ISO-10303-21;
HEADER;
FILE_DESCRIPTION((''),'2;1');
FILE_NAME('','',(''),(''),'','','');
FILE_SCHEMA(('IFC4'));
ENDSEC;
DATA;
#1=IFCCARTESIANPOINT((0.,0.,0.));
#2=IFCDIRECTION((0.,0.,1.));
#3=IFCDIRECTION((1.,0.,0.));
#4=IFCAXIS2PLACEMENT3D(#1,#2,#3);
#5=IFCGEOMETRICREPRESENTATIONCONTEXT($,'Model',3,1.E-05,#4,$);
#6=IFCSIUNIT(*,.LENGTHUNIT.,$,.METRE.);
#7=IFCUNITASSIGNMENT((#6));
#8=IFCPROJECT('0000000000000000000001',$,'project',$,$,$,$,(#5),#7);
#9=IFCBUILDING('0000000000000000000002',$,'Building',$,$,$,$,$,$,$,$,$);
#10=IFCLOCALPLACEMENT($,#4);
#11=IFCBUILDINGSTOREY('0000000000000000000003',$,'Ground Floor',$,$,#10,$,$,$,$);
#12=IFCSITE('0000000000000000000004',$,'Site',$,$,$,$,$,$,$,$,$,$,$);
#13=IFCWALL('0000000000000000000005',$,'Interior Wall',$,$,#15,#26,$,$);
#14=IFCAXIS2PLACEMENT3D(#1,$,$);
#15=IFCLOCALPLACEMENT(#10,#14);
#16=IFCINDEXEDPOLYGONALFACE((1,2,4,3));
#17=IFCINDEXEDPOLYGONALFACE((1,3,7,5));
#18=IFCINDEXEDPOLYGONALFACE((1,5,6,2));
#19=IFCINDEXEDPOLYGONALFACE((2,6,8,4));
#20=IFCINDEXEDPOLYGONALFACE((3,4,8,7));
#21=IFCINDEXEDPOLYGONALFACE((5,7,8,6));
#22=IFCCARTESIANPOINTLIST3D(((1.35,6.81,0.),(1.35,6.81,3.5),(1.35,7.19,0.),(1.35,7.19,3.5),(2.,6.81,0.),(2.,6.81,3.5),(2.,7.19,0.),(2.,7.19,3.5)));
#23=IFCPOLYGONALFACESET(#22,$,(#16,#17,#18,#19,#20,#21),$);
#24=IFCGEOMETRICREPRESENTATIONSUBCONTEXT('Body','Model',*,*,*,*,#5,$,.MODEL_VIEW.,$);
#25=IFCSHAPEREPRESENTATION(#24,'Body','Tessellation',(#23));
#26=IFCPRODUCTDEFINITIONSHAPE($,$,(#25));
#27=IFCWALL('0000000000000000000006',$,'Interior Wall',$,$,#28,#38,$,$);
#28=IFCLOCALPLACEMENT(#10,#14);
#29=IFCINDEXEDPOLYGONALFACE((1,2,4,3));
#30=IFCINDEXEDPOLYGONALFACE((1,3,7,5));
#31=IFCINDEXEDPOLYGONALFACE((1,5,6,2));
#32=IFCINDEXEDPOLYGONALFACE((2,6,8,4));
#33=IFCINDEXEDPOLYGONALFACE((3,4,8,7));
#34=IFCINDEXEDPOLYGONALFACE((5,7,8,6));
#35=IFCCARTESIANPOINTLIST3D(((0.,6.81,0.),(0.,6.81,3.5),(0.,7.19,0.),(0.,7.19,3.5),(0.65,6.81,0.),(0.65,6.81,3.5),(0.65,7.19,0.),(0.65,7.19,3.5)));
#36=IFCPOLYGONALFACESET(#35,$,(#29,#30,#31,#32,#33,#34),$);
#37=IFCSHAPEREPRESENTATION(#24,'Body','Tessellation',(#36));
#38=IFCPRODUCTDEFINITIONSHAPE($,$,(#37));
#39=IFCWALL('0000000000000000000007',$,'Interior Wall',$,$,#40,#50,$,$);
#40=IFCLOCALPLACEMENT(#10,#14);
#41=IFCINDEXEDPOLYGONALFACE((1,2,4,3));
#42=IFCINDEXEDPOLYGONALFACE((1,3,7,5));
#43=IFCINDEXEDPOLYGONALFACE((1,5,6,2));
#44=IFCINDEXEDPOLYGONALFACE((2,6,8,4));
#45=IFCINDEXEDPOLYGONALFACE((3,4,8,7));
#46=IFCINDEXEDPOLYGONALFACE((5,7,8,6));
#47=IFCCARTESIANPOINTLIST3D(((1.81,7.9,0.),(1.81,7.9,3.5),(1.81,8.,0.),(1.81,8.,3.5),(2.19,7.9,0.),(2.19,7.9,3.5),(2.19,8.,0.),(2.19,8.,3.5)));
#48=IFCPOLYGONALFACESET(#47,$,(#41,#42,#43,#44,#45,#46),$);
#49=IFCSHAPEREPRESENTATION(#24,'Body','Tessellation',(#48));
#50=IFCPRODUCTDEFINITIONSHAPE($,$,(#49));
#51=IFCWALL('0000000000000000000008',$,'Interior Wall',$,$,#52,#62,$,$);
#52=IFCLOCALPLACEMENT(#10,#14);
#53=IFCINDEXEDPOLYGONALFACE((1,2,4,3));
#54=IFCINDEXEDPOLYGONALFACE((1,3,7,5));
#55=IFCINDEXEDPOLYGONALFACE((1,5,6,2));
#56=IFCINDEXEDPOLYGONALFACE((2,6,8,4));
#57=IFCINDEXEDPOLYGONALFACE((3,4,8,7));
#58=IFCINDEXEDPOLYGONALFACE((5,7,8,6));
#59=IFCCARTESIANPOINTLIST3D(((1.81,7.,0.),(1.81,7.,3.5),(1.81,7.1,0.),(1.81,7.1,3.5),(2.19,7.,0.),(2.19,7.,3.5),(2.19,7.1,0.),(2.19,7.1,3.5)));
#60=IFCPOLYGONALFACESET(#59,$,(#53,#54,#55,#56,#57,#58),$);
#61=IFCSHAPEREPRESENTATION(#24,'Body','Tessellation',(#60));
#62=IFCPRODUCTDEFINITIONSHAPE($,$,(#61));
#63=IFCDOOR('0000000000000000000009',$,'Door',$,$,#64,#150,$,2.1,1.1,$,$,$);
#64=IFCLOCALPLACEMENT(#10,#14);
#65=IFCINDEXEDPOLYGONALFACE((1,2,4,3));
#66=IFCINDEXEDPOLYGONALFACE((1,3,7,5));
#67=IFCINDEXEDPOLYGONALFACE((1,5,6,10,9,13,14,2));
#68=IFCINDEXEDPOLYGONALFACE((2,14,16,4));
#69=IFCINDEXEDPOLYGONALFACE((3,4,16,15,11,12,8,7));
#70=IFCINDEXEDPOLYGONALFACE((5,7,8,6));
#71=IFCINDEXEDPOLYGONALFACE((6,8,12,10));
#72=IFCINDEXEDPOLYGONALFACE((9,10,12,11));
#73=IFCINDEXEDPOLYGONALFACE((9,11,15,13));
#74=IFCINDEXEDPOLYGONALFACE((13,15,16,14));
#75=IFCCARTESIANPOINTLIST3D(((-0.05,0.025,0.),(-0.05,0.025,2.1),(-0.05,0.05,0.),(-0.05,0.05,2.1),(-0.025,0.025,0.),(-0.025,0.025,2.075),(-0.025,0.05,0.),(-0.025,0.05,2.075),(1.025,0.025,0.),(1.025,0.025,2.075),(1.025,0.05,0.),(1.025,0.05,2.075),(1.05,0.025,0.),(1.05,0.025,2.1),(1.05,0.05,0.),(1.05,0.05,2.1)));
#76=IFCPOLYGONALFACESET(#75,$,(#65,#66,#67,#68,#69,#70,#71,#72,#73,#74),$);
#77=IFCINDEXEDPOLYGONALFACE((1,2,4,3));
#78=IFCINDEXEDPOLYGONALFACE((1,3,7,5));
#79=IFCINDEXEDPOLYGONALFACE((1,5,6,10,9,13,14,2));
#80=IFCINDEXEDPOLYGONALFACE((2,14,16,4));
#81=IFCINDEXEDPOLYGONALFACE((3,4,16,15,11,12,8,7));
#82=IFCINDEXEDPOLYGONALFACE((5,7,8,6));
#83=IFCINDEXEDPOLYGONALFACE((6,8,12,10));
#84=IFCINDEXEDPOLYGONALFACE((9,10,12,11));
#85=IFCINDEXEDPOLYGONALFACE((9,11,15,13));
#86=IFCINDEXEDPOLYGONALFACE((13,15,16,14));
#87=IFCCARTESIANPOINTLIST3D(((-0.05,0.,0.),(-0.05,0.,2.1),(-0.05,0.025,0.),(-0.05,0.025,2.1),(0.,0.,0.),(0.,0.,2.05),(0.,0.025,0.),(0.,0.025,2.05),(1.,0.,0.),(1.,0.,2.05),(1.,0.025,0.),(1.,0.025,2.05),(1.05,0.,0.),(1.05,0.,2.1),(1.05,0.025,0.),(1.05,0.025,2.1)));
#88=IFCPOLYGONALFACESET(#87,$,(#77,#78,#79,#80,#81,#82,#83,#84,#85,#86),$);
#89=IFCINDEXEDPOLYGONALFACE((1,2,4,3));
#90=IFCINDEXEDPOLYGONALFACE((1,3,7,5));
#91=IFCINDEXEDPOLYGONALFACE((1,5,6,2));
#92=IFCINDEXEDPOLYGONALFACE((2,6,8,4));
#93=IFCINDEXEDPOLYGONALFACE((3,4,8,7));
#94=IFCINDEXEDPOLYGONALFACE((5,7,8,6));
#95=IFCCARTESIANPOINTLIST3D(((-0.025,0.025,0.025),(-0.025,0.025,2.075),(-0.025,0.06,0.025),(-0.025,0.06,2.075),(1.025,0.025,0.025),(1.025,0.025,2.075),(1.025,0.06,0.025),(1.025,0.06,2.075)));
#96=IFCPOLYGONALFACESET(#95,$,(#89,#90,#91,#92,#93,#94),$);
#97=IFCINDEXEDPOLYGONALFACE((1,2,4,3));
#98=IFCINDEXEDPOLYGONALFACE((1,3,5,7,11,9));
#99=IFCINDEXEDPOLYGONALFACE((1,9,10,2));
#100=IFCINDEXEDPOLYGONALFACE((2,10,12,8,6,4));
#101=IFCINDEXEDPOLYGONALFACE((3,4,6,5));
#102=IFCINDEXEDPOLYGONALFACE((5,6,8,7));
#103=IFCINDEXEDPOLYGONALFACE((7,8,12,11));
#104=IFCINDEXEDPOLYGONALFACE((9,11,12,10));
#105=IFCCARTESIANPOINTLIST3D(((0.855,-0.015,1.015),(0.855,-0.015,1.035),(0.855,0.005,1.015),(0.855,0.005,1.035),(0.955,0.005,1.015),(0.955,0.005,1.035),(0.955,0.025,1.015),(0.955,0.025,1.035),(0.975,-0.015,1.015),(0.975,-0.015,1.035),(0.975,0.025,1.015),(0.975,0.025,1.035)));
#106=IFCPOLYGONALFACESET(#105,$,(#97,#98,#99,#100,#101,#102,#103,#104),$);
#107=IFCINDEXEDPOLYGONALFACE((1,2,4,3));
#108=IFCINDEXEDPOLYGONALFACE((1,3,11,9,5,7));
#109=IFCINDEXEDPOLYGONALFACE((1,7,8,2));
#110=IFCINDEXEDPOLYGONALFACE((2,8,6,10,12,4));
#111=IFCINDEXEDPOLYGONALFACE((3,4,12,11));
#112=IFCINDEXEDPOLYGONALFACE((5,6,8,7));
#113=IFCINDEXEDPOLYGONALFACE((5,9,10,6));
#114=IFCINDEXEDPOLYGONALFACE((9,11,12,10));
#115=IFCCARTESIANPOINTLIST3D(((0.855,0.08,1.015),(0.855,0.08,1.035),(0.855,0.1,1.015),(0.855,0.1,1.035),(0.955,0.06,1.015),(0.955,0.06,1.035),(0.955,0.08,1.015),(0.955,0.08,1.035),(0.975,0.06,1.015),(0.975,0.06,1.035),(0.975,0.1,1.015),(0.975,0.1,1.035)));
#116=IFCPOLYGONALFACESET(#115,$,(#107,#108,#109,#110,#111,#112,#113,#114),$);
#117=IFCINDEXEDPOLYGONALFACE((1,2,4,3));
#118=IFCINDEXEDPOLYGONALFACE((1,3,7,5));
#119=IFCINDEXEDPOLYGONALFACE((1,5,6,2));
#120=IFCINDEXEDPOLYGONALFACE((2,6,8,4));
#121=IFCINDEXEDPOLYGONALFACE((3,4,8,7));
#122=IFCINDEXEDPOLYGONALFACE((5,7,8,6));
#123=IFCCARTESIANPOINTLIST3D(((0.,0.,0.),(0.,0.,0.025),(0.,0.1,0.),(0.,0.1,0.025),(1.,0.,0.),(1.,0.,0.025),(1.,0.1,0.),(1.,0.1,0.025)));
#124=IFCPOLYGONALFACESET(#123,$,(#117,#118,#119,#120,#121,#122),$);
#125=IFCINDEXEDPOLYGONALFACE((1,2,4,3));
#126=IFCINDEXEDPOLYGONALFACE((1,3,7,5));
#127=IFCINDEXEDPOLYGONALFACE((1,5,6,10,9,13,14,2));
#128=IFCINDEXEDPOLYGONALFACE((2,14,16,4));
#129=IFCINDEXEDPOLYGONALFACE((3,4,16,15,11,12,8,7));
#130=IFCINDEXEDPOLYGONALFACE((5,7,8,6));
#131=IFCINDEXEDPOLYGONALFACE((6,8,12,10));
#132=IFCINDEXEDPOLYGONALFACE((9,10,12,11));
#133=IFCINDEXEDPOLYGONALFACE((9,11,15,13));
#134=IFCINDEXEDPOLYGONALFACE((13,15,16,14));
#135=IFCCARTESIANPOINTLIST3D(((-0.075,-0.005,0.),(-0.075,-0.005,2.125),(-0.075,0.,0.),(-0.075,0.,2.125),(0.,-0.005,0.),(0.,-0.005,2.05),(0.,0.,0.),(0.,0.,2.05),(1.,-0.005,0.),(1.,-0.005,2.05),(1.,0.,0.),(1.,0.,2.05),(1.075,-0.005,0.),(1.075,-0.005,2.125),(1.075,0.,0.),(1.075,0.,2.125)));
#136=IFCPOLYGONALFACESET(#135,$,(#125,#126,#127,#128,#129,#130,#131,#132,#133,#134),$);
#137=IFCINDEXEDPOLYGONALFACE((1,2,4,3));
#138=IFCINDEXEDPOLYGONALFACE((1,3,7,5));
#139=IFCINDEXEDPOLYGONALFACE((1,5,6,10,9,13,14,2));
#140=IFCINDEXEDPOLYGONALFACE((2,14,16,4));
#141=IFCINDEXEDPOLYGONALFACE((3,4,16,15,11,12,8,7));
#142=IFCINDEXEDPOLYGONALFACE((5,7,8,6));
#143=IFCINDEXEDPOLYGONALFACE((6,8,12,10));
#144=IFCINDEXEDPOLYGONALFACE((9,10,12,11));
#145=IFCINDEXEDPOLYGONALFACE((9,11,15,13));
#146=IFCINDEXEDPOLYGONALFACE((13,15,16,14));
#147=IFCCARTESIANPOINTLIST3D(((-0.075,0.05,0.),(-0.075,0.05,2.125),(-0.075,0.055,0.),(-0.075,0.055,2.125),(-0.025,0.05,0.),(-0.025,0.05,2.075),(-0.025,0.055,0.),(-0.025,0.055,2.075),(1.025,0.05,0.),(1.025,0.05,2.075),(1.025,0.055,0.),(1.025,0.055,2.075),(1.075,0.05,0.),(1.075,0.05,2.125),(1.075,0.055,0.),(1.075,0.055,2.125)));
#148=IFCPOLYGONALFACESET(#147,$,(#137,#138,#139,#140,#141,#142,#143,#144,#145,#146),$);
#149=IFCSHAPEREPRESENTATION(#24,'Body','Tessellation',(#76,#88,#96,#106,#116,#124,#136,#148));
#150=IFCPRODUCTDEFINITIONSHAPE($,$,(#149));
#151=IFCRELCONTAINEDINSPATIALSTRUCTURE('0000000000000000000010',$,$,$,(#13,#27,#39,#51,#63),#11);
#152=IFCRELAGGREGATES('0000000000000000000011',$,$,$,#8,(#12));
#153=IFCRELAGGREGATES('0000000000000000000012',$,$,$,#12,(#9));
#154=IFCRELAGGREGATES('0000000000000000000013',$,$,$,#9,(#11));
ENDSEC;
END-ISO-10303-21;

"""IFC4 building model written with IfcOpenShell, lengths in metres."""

from ifc_helpers import new_model, si_unit, frame, origin_with_axes, place, context, subcontext, project, spatial, line, indexed_curve, outline, extrude, element, save


model = new_model("IFC4")

# Units and contexts
model_context = context("Model", 3, precision=1e-05, world=origin_with_axes())
body_context = subcontext(model_context, "Body", "Model", "MODEL_VIEW")
ifc_project = project(units=[si_unit("LENGTHUNIT", "METRE")], contexts=[model_context])

# Site, building, storey
site = spatial("IfcSite", under=ifc_project, Name="Site")
building = spatial("IfcBuilding", under=site, Name="Building")
storey_placement = place(None, origin_with_axes())
storey = spatial("IfcBuildingStorey", under=building, at=storey_placement, Name="Ground Floor")

# Walls
for number, where, z_axis, x_axis, name in (
    (1, (2.0, 7.0, 0.0), (0.0, 0.0, 1.0), (-1.0, 0.0, 0.0), "Interior Wall"),
    (2, (0.65, 7.0, 0.0), (0.0, 0.0, 1.0), (-1.0, 0.0, 0.0), "Interior Wall"),
):
    element("IfcWall", number, at=place(storey_placement, frame(where, z_axis=z_axis, x_axis=x_axis)), inside=storey, Name=name, context=body_context, shape_type="SweptSolid", body=[
        extrude(outline(indexed_curve([(0.0, 0.0), (0.0, 0.38), (0.65, 0.38), (0.65, 0.0), (0.0, 0.0)], self_intersect=False)), frame((0.0, -0.19, 0.0), z_axis=(0.0, 0.0, 1.0), x_axis=(1.0, 0.0, 0.0)), (0.0, 0.0, 1.0), 3.5),
    ])
for number, where, z_axis, x_axis, name in (
    (3, (2.0, 8.0, 0.0), (0.0, 0.0, 1.0), (0.0, -1.0, 0.0), "Interior Wall"),
    (4, (2.0, 7.1, 0.0), (0.0, 0.0, 1.0), (0.0, -1.0, 0.0), "Interior Wall"),
):
    element("IfcWall", number, at=place(storey_placement, frame(where, z_axis=z_axis, x_axis=x_axis)), inside=storey, Name=name, context=body_context, shape_type="SweptSolid", body=[
        extrude(outline(indexed_curve([(0.0, 0.0), (0.0, 0.38), (0.1, 0.38), (0.1, 0.0), (0.0, 0.0)], self_intersect=False)), frame((0.0, -0.19, 0.0), z_axis=(0.0, 0.0, 1.0), x_axis=(1.0, 0.0, 0.0)), (0.0, 0.0, 1.0), 3.5),
    ])

# Door
door_1_placement = place(storey_placement, frame((-0.05, 0.0, 0.0), z_axis=(0.0, 0.0, 1.0), x_axis=(1.0, 0.0, 0.0)))
element("IfcDoor", 5, at=door_1_placement, inside=storey, Name="Door", OverallHeight=2.1, OverallWidth=1.1, context=body_context, shape_type="SweptSolid", body=[
    extrude(outline(indexed_curve([(0.0, 0.0), (0.0, 2.1), (1.1, 2.1), (1.1, 0.0), (1.075, 0.0), (1.075, 2.075), (0.025, 2.075), (0.025, 0.0)], segments=[line(1, 2, 3, 4, 5, 6, 7, 8, 1)])), frame((0.0, 0.025, 0.0), z_axis=(0.0, -1.0, 0.0), x_axis=(1.0, 0.0, 0.0)), (0.0, 0.0, -1.0), 0.025),
    extrude(outline(indexed_curve([(0.0, 0.0), (0.0, 2.1), (1.1, 2.1), (1.1, 0.0), (1.05, 0.0), (1.05, 2.05), (0.05, 2.05), (0.05, 0.0)], segments=[line(1, 2, 3, 4, 5, 6, 7, 8, 1)])), frame((0.0, 0.0, 0.0), z_axis=(0.0, -1.0, 0.0), x_axis=(1.0, 0.0, 0.0)), (0.0, 0.0, -1.0), 0.025),
    extrude(outline(indexed_curve([(0.0, 0.0), (1.05, 0.0), (1.05, 0.035), (0.0, 0.035)], segments=[line(1, 2, 3, 4, 1)])), frame((0.025, 0.025, 0.025), z_axis=(0.0, 0.0, 1.0), x_axis=(1.0, 0.0, 0.0)), (0.0, 0.0, 1.0), 2.05),
    extrude(outline(indexed_curve([(0.0, 0.0), (0.0, -0.04), (-0.12, -0.04), (-0.12, -0.02), (-0.02, -0.02), (-0.02, 0.0)], segments=[line(1, 2, 3, 4, 5, 6, 1)])), frame((1.025, 0.025, 1.015), z_axis=(0.0, 0.0, 1.0), x_axis=(1.0, 0.0, 0.0)), (0.0, 0.0, 1.0), 0.02),
    extrude(outline(indexed_curve([(0.0, 0.0), (0.0, 0.04), (-0.12, 0.04), (-0.12, 0.02), (-0.02, 0.02), (-0.02, 0.0)], segments=[line(1, 2, 3, 4, 5, 6, 1)])), frame((1.025, 0.06, 1.015), z_axis=(0.0, 0.0, 1.0), x_axis=(1.0, 0.0, 0.0)), (0.0, 0.0, 1.0), 0.02),
    extrude(outline(indexed_curve([(0.0, 0.0), (1.0, 0.0), (1.0, 0.1), (0.0, 0.1)], segments=[line(1, 2, 3, 4, 1)])), frame((0.05, 0.0, 0.0), z_axis=(0.0, 0.0, 1.0), x_axis=(1.0, 0.0, 0.0)), (0.0, 0.0, 1.0), 0.025),
    extrude(outline(indexed_curve([(0.0, 0.0), (0.0, 2.125), (1.15, 2.125), (1.15, 0.0), (1.075, 0.0), (1.075, 2.05), (0.075, 2.05), (0.075, 0.0)], segments=[line(1, 2, 3, 4, 5, 6, 7, 8, 1)])), frame((-0.025, -0.005, 0.0), z_axis=(0.0, -1.0, 0.0), x_axis=(1.0, 0.0, 0.0)), (0.0, 0.0, -1.0), 0.005),
    extrude(outline(indexed_curve([(0.0, 0.0), (0.0, 2.125), (1.15, 2.125), (1.15, 0.0), (1.1, 0.0), (1.1, 2.075), (0.05, 2.075), (0.05, 0.0)], segments=[line(1, 2, 3, 4, 5, 6, 7, 8, 1)])), frame((-0.025, 0.05, 0.0), z_axis=(0.0, -1.0, 0.0), x_axis=(1.0, 0.0, 0.0)), (0.0, 0.0, -1.0), 0.005),
])

save(model, "model.ifc")
